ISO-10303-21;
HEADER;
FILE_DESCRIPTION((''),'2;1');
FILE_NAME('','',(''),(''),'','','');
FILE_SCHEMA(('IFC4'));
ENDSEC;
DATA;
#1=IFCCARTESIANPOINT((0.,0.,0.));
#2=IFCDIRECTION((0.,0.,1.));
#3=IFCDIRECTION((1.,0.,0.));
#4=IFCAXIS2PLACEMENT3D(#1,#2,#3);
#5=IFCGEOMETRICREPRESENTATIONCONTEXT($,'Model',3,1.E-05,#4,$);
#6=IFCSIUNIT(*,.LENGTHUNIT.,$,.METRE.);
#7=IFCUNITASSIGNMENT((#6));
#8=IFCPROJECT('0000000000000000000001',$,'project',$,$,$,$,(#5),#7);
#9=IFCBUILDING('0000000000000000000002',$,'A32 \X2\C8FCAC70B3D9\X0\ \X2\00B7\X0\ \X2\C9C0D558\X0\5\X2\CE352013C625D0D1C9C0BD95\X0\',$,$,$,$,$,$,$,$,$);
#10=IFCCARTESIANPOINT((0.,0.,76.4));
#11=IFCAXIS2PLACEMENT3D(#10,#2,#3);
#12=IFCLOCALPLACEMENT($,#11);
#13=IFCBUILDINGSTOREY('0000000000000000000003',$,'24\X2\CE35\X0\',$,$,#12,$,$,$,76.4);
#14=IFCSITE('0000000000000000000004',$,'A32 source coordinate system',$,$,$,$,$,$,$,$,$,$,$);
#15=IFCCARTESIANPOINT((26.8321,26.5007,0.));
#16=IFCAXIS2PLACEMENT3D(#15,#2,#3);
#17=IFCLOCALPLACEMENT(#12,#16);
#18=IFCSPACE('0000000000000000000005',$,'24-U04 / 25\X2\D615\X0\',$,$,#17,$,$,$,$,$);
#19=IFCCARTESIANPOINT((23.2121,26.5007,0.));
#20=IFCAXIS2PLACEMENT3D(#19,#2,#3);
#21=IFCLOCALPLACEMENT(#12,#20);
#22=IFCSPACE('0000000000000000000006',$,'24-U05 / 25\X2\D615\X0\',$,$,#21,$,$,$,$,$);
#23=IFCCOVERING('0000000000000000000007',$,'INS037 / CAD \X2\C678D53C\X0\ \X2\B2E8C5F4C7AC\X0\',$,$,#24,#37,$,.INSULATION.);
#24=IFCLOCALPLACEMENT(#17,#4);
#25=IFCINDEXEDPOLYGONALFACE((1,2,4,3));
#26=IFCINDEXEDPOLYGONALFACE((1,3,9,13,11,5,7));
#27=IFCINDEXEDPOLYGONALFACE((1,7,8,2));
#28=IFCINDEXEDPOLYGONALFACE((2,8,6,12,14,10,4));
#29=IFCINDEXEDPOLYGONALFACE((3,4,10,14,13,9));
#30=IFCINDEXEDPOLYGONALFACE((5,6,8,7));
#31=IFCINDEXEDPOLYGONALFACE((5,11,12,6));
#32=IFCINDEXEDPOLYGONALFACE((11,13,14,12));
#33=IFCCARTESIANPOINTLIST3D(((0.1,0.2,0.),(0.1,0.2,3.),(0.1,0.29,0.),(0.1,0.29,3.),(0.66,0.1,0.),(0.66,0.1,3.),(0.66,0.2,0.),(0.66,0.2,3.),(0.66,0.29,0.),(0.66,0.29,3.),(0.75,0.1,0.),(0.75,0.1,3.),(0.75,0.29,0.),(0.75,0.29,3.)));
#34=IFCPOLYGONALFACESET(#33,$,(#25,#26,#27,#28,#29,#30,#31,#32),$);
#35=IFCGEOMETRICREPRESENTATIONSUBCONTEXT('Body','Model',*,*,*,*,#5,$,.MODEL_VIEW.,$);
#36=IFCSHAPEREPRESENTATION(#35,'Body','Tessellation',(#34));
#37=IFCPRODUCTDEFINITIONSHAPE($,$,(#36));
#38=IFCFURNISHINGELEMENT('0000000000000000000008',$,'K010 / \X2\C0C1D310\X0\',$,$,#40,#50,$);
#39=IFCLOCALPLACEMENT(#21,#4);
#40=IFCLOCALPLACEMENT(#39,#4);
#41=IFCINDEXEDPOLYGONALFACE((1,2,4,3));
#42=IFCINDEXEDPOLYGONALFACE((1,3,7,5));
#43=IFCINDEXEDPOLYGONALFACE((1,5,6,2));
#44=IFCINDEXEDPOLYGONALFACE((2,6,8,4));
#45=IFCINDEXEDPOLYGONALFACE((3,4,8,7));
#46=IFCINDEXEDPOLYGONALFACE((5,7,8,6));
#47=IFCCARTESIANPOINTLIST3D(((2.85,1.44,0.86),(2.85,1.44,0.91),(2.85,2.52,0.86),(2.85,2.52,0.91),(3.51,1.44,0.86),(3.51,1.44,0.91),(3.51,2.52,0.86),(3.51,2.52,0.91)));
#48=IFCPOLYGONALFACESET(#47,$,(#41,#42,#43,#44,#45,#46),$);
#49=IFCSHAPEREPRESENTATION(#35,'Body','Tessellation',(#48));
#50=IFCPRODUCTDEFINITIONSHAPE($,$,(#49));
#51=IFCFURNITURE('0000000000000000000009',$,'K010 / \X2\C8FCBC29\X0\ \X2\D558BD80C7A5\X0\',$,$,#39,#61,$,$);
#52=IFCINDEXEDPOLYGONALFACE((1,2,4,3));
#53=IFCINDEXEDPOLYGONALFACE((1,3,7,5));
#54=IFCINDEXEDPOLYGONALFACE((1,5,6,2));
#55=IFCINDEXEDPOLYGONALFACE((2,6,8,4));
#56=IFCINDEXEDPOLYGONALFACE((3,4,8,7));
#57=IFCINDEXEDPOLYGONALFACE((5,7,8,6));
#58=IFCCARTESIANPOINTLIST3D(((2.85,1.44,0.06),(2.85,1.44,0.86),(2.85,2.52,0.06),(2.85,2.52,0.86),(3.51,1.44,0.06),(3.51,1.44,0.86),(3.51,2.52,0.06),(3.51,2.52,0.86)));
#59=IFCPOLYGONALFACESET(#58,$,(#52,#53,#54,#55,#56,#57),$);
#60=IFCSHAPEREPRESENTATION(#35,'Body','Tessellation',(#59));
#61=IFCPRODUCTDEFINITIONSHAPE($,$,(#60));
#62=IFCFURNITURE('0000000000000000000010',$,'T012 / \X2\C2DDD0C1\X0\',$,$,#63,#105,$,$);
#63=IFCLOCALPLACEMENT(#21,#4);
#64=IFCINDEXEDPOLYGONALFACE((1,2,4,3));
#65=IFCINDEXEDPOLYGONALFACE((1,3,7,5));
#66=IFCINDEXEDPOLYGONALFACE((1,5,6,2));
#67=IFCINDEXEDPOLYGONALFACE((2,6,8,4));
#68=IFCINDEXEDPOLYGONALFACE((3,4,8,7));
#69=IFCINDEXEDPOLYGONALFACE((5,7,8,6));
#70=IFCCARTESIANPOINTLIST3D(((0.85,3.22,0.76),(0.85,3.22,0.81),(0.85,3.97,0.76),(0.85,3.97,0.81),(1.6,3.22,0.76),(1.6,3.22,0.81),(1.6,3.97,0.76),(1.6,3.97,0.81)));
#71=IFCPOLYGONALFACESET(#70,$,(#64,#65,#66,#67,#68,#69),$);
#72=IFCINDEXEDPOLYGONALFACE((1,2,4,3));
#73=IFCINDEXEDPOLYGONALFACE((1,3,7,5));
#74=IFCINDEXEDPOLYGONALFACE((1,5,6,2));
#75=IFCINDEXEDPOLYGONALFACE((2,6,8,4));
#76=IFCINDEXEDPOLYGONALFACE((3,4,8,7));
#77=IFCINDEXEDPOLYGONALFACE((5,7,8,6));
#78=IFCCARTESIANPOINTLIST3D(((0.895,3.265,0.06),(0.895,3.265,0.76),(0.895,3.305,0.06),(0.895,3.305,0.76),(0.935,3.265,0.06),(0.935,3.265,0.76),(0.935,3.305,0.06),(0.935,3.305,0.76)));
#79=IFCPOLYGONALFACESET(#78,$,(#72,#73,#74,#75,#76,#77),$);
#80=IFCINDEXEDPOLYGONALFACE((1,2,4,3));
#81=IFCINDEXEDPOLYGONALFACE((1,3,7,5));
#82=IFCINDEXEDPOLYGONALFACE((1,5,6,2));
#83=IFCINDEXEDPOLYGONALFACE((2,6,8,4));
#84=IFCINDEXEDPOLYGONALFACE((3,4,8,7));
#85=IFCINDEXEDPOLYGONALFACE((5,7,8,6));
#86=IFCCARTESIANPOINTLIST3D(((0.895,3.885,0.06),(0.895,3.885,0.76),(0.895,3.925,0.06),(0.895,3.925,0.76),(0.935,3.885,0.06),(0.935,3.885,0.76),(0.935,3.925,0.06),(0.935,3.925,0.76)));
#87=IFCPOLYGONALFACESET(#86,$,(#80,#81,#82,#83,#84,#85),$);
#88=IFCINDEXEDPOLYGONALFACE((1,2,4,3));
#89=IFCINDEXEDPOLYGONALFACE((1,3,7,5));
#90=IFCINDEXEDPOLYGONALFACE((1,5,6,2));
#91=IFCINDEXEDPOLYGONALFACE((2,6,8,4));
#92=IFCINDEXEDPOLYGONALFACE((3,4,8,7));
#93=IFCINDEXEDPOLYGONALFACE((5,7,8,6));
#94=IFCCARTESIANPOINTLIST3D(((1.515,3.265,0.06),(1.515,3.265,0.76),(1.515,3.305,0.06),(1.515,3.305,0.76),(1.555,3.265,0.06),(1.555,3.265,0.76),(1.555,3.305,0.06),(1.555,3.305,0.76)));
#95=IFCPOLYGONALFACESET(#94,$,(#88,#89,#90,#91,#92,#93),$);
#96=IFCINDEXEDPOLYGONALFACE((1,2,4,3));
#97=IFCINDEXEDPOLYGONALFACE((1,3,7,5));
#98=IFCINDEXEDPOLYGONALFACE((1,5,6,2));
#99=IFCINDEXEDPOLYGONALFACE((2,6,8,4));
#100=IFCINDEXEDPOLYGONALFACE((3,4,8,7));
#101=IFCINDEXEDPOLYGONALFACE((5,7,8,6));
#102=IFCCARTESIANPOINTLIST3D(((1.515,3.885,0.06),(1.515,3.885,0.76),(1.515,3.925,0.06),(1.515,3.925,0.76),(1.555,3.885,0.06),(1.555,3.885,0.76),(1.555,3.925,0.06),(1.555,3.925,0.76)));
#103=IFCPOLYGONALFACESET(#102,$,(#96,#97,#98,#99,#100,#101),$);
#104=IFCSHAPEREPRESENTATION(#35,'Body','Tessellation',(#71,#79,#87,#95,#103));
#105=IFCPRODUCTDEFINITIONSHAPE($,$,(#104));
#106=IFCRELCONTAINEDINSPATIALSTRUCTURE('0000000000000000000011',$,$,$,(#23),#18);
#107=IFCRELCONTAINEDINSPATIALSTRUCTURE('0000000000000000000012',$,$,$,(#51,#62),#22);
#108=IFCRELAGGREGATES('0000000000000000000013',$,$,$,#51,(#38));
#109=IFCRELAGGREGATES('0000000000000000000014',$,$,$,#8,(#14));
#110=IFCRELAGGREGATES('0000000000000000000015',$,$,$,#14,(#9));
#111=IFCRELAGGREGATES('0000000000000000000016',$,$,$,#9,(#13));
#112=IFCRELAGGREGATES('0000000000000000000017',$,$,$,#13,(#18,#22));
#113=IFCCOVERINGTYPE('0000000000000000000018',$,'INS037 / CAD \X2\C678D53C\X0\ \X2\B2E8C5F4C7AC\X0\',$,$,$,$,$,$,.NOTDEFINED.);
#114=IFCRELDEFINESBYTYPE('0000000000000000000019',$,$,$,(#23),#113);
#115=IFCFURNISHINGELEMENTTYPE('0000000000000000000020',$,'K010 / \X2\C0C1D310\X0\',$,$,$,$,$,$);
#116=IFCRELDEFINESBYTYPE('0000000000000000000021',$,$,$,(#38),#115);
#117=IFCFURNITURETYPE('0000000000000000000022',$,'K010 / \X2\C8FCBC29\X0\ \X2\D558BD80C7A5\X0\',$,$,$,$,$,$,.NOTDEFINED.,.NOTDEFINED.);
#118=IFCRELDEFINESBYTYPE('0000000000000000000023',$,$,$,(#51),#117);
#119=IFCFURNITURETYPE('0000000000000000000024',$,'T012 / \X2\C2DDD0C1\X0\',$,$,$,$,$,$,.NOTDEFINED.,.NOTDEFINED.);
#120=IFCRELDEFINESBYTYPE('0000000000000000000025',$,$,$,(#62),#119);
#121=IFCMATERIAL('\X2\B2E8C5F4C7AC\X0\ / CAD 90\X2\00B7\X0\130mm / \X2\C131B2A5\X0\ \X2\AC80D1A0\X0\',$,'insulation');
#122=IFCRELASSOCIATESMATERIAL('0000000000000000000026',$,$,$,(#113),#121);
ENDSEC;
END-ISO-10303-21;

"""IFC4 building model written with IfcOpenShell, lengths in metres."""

from ifc_helpers import new_model, si_unit, frame, origin, origin_with_axes, place, context, subcontext, project, spatial, polyline, outline, extrude, source, transform, mapped, material, type_object, type_shapes, element, aggregate, save


model = new_model("IFC4")

# Units and contexts
model_context = context("Model", 3, precision=1e-05, world=origin_with_axes())
body_context = subcontext(model_context, "Body", "Model", "MODEL_VIEW")
ifc_project = project(units=[si_unit("LENGTHUNIT", "METRE")], contexts=[model_context])

# Site, building, storey, space
storey_placement = place(None, frame((0.0, 0.0, 76.4), z_axis=(0.0, 0.0, 1.0), x_axis=(1.0, 0.0, 0.0)))
space_1_placement = place(storey_placement, frame((26.8321, 26.5007, 0.0), z_axis=(0.0, 0.0, 1.0), x_axis=(1.0, 0.0, 0.0)))
site = spatial("IfcSite", under=ifc_project, Name="A32 source coordinate system")
building = spatial("IfcBuilding", under=site, Name="A32 주거동 · 지하5층–옥탑지붕")
storey = spatial("IfcBuildingStorey", under=building, at=storey_placement, Name="24층", Elevation=76.4)
space_1 = spatial("IfcSpace", under=storey, at=space_1_placement, Name="24-U04 / 25형")

# Shared definitions
space_2_placement = place(storey_placement, frame((23.2121, 26.5007, 0.0), z_axis=(0.0, 0.0, 1.0), x_axis=(1.0, 0.0, 0.0)))
space_2 = spatial("IfcSpace", under=storey, at=space_2_placement, Name="24-U05 / 25형")

# Covering
ifc_material = material(Name="단열재 / CAD 90·130mm / 성능 검토", Category="insulation")
covering_type_1 = type_object("IfcCoveringType", Name="INS037 / CAD 외피 단열재", PredefinedType="NOTDEFINED", material=ifc_material)
shared_shape_1 = source(origin(), body_context, "Body", "SweptSolid", [
    extrude(outline(polyline([(0.1, 0.2), (0.1, 0.29), (0.66, 0.29), (0.75, 0.29), (0.75, 0.1), (0.66, 0.1), (0.66, 0.2), (0.1, 0.2)])), origin(), (0.0, 0.0, 1.0), 3.0),
])
type_shapes(covering_type_1, [shared_shape_1])
covering_1_placement = place(space_1_placement, origin_with_axes())
element("IfcCovering", 1, at=covering_1_placement, inside=space_1, type_object=covering_type_1, Name="INS037 / CAD 외피 단열재", PredefinedType="INSULATION", context=body_context, shape_type="MappedRepresentation", body=[
    mapped(shared_shape_1, transform((0.0, 0.0, 0.0), scale=1.0)),
])

# Furnishing element
furnishing_element_type_1 = type_object("IfcFurnishingElementType", Name="K010 / 상판")
shared_shape_2 = source(origin(), body_context, "Body", "SweptSolid", [
    extrude(outline(polyline([(2.85, 2.52), (3.51, 2.52), (3.51, 1.44), (2.85, 1.44), (2.85, 2.52)])), frame((0.0, 0.0, 0.86)), (0.0, 0.0, 1.0), 0.05),
])
type_shapes(furnishing_element_type_1, [shared_shape_2])
furniture_1_placement = place(space_2_placement, origin_with_axes())
furnishing_1_placement = place(furniture_1_placement, origin_with_axes())
furnishing_1 = element("IfcFurnishingElement", 2, at=furnishing_1_placement, type_object=furnishing_element_type_1, Name="K010 / 상판", context=body_context, shape_type="MappedRepresentation", body=[
    mapped(shared_shape_2, transform((0.0, 0.0, 0.0), scale=1.0)),
])

# Furniture
furniture_type_1 = type_object("IfcFurnitureType", Name="K010 / 주방 하부장", AssemblyPlace="NOTDEFINED", PredefinedType="NOTDEFINED")
shared_shape_3 = source(origin(), body_context, "Body", "SweptSolid", [
    extrude(outline(polyline([(2.85, 1.44), (2.85, 2.52), (3.51, 2.52), (3.51, 1.44), (2.85, 1.44)])), frame((0.0, 0.0, 0.06)), (0.0, 0.0, 1.0), 0.8),
])
type_shapes(furniture_type_1, [shared_shape_3])
furniture_1 = element("IfcFurniture", 3, at=furniture_1_placement, inside=space_2, type_object=furniture_type_1, Name="K010 / 주방 하부장", context=body_context, shape_type="MappedRepresentation", body=[
    mapped(shared_shape_3, transform((0.0, 0.0, 0.0), scale=1.0)),
])
aggregate(furniture_1, [furnishing_1])
furniture_type_2 = type_object("IfcFurnitureType", Name="T012 / 식탁", AssemblyPlace="NOTDEFINED", PredefinedType="NOTDEFINED")
shared_shape_4 = source(origin(), body_context, "Body", "SweptSolid", [
    extrude(outline(polyline([(1.6, 3.97), (1.6, 3.22), (0.85, 3.22), (0.85, 3.97), (1.6, 3.97)])), frame((0.0, 0.0, 0.76)), (0.0, 0.0, 1.0), 0.05),
    extrude(outline(polyline([(0.895, 3.265), (0.895, 3.305), (0.935, 3.305), (0.935, 3.265), (0.895, 3.265)])), frame((0.0, 0.0, 0.06)), (0.0, 0.0, 1.0), 0.7),
    extrude(outline(polyline([(0.895, 3.885), (0.895, 3.925), (0.935, 3.925), (0.935, 3.885), (0.895, 3.885)])), frame((0.0, 0.0, 0.06)), (0.0, 0.0, 1.0), 0.7),
    extrude(outline(polyline([(1.515, 3.265), (1.515, 3.305), (1.555, 3.305), (1.555, 3.265), (1.515, 3.265)])), frame((0.0, 0.0, 0.06)), (0.0, 0.0, 1.0), 0.7),
    extrude(outline(polyline([(1.515, 3.885), (1.515, 3.925), (1.555, 3.925), (1.555, 3.885), (1.515, 3.885)])), frame((0.0, 0.0, 0.06)), (0.0, 0.0, 1.0), 0.7),
])
type_shapes(furniture_type_2, [shared_shape_4])
furniture_2_placement = place(space_2_placement, origin_with_axes())
element("IfcFurniture", 4, at=furniture_2_placement, inside=space_2, type_object=furniture_type_2, Name="T012 / 식탁", context=body_context, shape_type="MappedRepresentation", body=[
    mapped(shared_shape_4, transform((0.0, 0.0, 0.0), scale=1.0)),
])

save(model, "model.ifc")
